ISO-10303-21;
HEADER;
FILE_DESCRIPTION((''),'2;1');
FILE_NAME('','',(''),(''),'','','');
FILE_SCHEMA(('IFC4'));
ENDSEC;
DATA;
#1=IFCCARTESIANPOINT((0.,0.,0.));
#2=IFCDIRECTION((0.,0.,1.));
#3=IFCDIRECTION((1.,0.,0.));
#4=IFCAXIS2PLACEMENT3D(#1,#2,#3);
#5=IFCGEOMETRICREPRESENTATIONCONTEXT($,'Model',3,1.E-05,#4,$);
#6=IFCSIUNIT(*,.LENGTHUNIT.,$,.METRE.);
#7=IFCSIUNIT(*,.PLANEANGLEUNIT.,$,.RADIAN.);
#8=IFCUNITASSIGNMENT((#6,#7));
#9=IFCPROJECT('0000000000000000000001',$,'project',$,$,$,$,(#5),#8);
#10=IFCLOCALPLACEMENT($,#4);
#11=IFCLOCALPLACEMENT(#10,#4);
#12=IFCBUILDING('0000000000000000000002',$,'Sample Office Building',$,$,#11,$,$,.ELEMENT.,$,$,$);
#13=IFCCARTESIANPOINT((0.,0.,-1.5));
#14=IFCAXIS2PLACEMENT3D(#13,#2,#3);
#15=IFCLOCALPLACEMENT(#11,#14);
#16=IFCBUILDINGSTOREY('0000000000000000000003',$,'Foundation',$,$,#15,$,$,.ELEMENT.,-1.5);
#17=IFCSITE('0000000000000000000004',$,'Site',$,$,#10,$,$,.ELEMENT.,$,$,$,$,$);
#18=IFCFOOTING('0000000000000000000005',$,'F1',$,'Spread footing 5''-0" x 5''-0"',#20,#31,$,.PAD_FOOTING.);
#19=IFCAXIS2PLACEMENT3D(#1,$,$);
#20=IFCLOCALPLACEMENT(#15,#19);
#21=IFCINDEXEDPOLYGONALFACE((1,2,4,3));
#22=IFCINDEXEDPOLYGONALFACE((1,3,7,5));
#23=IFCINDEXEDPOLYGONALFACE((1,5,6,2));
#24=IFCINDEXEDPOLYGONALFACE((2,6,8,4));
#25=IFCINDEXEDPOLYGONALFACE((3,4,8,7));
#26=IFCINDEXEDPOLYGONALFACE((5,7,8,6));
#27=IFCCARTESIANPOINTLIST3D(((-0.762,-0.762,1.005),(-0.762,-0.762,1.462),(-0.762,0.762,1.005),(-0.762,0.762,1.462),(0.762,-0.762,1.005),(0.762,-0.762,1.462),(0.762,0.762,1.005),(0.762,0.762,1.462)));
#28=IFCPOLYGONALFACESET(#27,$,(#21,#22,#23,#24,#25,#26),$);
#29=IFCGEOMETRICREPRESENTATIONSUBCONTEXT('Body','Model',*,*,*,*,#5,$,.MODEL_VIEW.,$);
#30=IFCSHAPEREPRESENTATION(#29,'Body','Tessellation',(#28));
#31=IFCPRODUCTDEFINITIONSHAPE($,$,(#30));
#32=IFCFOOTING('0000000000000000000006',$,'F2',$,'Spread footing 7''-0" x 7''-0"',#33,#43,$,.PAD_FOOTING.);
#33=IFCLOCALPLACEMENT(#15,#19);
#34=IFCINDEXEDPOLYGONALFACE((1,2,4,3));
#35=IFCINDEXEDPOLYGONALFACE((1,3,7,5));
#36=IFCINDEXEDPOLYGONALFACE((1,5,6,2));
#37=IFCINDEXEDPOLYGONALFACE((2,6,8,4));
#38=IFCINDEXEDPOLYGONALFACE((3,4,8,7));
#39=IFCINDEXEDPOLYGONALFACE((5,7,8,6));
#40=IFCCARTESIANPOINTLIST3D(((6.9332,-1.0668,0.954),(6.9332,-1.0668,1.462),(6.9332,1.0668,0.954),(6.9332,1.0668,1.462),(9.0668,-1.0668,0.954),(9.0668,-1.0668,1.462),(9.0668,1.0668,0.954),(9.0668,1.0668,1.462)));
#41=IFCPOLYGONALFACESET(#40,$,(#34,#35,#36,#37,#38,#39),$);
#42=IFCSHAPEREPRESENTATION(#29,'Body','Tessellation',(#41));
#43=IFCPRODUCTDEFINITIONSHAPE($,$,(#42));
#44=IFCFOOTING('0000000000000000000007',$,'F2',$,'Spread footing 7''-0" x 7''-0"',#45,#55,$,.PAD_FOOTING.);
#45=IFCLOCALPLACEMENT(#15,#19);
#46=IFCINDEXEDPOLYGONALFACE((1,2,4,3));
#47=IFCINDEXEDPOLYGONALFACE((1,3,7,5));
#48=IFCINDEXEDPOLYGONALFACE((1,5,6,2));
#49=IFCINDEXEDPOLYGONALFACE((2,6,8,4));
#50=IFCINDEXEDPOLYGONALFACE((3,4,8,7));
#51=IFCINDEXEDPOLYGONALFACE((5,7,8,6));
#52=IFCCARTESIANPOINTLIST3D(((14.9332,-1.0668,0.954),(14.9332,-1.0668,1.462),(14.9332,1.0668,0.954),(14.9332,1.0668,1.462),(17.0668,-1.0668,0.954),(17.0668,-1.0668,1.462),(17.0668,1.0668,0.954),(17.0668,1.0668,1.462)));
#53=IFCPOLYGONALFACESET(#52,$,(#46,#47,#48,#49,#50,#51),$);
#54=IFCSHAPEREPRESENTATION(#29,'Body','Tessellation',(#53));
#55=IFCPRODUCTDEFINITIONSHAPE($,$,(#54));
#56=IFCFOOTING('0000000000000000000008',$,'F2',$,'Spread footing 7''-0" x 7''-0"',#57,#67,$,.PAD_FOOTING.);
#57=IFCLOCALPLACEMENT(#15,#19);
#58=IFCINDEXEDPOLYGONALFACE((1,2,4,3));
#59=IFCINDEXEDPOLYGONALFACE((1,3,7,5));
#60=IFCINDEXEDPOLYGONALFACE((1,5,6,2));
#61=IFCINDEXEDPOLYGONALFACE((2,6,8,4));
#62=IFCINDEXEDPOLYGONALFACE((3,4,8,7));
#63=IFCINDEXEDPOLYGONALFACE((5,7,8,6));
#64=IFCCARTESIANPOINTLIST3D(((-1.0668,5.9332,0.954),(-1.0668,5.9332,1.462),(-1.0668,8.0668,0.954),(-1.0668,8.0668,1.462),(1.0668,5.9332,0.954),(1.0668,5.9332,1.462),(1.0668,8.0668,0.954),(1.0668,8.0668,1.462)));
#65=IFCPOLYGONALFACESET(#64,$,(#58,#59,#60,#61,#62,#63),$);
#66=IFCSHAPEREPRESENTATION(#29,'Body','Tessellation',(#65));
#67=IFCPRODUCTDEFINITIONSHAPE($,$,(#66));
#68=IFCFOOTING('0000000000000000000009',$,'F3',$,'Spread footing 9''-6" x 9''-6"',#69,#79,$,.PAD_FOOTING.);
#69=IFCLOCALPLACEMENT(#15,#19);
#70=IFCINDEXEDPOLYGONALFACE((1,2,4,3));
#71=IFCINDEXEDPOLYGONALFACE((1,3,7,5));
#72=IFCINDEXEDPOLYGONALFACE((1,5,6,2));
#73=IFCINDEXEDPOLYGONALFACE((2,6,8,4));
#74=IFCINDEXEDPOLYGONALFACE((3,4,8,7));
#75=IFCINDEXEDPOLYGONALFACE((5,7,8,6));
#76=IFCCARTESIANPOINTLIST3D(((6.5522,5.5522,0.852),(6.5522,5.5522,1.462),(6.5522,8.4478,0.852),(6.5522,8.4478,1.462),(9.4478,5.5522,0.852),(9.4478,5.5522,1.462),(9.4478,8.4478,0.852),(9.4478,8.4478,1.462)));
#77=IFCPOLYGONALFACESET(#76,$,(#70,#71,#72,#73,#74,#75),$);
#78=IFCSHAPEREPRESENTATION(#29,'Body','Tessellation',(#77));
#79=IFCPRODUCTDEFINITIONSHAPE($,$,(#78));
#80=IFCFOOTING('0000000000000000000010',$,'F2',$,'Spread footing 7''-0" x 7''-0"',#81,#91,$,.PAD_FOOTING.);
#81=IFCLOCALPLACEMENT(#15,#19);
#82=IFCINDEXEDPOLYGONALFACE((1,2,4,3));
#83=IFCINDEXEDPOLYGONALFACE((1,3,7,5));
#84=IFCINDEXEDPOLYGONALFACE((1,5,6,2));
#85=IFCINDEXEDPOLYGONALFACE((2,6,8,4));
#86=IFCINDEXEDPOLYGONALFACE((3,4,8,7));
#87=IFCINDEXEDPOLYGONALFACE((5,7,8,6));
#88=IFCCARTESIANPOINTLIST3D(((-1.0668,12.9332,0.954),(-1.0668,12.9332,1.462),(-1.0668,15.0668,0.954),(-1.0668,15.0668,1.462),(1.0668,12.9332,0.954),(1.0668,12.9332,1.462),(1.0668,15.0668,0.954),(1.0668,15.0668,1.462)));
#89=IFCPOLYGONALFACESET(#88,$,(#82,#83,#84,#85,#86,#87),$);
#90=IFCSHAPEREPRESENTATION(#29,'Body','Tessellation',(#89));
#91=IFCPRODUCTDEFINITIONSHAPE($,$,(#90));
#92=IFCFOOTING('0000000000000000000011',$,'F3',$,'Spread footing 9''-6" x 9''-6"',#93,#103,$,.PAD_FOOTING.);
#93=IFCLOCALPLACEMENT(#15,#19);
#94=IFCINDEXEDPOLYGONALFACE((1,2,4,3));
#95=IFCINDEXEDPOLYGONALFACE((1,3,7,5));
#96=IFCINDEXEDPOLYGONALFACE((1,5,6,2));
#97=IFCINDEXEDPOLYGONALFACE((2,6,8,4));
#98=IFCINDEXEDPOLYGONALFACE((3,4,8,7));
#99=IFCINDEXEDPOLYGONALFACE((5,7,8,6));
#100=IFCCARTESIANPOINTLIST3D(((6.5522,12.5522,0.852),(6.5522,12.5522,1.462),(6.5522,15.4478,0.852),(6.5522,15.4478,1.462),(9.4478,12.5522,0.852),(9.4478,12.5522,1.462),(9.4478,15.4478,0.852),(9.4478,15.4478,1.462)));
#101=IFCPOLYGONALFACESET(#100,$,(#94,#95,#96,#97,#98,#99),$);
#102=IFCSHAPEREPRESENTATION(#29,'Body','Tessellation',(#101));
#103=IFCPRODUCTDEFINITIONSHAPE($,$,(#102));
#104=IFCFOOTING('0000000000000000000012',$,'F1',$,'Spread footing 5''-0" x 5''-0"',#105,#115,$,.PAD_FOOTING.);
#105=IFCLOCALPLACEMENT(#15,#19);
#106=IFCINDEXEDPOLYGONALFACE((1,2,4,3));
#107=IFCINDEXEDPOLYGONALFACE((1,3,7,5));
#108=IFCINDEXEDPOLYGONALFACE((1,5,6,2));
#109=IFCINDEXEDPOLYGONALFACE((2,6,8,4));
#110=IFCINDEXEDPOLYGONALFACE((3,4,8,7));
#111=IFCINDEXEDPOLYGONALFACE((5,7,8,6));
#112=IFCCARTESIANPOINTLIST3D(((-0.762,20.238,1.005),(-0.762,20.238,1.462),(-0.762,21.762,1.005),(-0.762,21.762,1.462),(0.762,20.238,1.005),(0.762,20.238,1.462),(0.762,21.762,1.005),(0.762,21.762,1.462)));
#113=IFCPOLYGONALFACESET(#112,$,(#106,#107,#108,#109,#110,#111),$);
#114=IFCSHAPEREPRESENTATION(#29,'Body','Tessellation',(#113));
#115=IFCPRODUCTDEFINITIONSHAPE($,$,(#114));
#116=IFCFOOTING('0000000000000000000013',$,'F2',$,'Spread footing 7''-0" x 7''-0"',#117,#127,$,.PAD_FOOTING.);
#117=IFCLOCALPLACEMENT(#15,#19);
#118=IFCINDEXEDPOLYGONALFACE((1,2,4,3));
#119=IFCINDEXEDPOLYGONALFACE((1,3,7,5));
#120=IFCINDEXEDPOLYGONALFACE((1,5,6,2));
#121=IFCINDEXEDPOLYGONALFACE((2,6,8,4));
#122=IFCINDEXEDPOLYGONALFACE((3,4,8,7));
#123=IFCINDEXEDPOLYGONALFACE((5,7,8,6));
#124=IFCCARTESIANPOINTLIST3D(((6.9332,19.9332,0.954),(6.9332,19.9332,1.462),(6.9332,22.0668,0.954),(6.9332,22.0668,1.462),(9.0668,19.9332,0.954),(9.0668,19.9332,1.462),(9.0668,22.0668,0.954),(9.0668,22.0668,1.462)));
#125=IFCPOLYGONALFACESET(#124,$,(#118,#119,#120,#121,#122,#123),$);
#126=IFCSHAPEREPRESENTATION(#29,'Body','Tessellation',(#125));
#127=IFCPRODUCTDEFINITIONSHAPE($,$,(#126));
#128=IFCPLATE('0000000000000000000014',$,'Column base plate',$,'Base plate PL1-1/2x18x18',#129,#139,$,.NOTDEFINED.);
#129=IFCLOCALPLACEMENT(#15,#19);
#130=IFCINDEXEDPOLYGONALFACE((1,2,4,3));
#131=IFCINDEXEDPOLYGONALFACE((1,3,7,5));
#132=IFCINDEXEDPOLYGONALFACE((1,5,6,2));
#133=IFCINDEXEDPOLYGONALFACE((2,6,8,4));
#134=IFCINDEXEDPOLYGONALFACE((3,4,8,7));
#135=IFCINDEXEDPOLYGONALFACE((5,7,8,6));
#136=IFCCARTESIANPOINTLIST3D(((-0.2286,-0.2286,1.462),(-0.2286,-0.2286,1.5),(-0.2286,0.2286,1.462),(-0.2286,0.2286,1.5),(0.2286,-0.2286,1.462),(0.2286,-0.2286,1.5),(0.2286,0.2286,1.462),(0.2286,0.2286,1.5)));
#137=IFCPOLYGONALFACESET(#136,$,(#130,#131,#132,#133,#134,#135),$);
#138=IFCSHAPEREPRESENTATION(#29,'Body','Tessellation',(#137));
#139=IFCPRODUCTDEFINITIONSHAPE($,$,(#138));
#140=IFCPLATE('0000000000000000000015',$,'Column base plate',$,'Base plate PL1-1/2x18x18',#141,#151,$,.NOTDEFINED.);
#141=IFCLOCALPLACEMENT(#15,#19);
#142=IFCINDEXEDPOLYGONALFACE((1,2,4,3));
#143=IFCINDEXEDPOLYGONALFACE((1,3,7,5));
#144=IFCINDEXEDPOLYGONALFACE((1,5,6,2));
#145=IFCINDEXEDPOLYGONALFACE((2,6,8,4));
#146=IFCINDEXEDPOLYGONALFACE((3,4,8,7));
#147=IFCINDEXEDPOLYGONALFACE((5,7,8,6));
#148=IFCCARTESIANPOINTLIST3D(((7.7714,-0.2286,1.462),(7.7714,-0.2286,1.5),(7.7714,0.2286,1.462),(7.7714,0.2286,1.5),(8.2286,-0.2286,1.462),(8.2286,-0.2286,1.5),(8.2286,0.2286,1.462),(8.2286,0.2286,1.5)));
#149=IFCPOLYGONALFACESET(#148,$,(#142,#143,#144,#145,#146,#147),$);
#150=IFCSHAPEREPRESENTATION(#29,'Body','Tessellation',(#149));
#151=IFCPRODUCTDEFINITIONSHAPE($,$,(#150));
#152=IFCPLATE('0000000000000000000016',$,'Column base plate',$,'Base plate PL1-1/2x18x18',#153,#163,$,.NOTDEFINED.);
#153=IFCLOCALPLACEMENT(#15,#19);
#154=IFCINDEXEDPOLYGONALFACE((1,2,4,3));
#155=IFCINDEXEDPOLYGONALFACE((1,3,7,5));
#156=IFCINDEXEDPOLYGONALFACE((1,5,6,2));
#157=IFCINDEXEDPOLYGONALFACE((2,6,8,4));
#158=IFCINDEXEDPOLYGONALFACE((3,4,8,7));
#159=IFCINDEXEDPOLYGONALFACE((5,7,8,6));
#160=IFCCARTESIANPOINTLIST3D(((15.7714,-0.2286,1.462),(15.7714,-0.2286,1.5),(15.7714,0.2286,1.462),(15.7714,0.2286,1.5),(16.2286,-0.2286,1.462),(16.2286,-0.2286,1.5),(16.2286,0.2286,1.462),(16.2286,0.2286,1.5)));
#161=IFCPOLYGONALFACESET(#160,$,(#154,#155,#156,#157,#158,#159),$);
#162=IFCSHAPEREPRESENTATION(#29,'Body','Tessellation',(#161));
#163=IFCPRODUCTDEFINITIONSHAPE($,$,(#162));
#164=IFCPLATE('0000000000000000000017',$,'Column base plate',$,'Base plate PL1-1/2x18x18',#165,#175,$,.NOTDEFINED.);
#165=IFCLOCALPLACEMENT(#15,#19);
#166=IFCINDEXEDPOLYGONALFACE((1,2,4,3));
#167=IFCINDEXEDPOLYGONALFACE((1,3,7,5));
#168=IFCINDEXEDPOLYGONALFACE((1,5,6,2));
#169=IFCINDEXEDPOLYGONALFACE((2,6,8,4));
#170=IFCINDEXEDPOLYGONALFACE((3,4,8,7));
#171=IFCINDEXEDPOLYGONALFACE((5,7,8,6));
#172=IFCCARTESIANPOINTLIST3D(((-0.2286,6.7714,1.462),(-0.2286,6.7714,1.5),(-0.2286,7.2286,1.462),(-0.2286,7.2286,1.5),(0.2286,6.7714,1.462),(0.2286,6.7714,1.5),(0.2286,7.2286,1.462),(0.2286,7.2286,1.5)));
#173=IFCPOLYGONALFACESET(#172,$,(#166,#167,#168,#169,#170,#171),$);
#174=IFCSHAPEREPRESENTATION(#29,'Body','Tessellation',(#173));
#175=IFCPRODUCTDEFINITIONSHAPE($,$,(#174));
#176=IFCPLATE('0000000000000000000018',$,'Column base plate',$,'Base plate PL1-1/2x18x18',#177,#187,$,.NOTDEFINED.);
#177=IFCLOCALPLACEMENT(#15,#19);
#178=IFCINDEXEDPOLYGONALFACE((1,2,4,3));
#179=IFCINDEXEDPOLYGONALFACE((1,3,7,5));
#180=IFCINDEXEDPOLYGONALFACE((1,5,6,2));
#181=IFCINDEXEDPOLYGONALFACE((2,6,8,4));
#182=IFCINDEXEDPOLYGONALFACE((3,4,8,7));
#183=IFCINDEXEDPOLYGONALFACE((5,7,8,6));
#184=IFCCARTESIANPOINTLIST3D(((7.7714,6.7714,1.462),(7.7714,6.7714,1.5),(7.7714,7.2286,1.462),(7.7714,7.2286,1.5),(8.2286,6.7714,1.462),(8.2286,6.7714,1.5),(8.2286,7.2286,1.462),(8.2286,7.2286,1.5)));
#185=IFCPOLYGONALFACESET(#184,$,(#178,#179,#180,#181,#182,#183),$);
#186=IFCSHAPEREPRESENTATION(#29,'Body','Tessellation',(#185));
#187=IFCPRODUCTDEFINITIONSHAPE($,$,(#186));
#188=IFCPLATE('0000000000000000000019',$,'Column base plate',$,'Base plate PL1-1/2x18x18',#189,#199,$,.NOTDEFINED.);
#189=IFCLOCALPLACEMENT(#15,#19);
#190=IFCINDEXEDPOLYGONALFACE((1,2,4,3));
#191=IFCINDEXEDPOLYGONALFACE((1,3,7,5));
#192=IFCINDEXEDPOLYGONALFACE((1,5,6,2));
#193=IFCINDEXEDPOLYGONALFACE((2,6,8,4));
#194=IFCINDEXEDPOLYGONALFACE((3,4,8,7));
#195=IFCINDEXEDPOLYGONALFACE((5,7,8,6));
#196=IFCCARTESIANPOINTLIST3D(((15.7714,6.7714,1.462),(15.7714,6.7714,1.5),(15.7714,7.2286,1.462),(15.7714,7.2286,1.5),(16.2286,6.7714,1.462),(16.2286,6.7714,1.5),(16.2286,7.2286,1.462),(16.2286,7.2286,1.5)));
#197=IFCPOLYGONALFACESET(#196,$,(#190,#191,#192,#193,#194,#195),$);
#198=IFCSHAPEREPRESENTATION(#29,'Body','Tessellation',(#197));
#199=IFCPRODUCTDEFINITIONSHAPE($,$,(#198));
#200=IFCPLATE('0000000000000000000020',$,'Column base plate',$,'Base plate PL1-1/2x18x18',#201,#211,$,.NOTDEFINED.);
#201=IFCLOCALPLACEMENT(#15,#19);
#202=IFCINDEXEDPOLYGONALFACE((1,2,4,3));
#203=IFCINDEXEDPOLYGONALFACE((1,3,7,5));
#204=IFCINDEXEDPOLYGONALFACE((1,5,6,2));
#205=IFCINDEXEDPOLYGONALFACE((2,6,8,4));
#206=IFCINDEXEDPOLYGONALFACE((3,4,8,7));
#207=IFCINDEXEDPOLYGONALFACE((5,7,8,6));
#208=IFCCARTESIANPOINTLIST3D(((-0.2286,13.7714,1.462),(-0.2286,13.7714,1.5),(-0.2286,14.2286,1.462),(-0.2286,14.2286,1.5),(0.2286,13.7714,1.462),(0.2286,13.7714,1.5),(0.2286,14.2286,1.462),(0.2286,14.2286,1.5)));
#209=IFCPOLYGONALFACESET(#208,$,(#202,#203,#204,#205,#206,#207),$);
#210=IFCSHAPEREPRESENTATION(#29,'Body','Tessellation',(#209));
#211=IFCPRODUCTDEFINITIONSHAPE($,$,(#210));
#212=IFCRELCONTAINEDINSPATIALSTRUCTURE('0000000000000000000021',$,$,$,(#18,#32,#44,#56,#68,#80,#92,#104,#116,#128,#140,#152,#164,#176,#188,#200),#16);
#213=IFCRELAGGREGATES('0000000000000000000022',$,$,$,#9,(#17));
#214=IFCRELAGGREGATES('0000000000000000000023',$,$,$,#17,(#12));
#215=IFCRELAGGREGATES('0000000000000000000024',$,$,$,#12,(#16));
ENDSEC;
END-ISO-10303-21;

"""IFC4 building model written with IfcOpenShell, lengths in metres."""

from ifc_helpers import new_model, si_unit, frame, origin_with_axes, place, context, subcontext, project, spatial, rectangle, extrude, element, save


model = new_model("IFC4")

# Units and contexts
model_context = context("Model", 3, precision=1e-05, world=origin_with_axes())
body_context = subcontext(model_context, "Body", "Model", "MODEL_VIEW")
ifc_project = project(units=[si_unit("LENGTHUNIT", "METRE"), si_unit("PLANEANGLEUNIT", "RADIAN")], contexts=[model_context])

# Site, building, storey
site_placement = place(None, origin_with_axes())
site = spatial("IfcSite", under=ifc_project, at=site_placement, Name="Site", CompositionType="ELEMENT")
building_placement = place(site_placement, origin_with_axes())
building = spatial("IfcBuilding", under=site, at=building_placement, Name="Sample Office Building", CompositionType="ELEMENT")
storey_placement = place(building_placement, frame((0.0, 0.0, -1.5), z_axis=(0.0, 0.0, 1.0), x_axis=(1.0, 0.0, 0.0)))
storey = spatial("IfcBuildingStorey", under=building, at=storey_placement, Name="Foundation", CompositionType="ELEMENT", Elevation=-1.5)

# Footings
footing_1_placement = place(None, frame((0.0, 0.0, -0.495), z_axis=(0.0, 0.0, 1.0), x_axis=(1.0, 0.0, 0.0)))
element("IfcFooting", 1, at=footing_1_placement, inside=storey, Name="F1", ObjectType="Spread footing 5'-0\" x 5'-0\"", PredefinedType="PAD_FOOTING", context=body_context, shape_type="SweptSolid", body=[
    extrude(rectangle(XDim=1.524, YDim=1.524), None, (0.0, 0.0, 1.0), 0.457),
])
for number, where, z_axis, x_axis, name in (
    (2, (8.0, 0.0, -0.546), (0.0, 0.0, 1.0), (1.0, 0.0, 0.0), "F2"),
    (3, (16.0, 0.0, -0.546), (0.0, 0.0, 1.0), (1.0, 0.0, 0.0), "F2"),
):
    element("IfcFooting", number, at=place(None, frame(where, z_axis=z_axis, x_axis=x_axis)), inside=storey, Name=name, ObjectType="Spread footing 7'-0\" x 7'-0\"", PredefinedType="PAD_FOOTING", context=body_context, shape_type="SweptSolid", body=[
        extrude(rectangle(XDim=2.1336, YDim=2.1336), None, (0.0, 0.0, 1.0), 0.508),
    ])
footing_2_placement = place(None, frame((0.0, 7.0, -0.546), z_axis=(0.0, 0.0, 1.0), x_axis=(1.0, 0.0, 0.0)))
element("IfcFooting", 4, at=footing_2_placement, inside=storey, Name="F2", ObjectType="Spread footing 7'-0\" x 7'-0\"", PredefinedType="PAD_FOOTING", context=body_context, shape_type="SweptSolid", body=[
    extrude(rectangle(XDim=2.1336, YDim=2.1336), None, (0.0, 0.0, 1.0), 0.508),
])
footing_3_placement = place(None, frame((8.0, 7.0, -0.648), z_axis=(0.0, 0.0, 1.0), x_axis=(1.0, 0.0, 0.0)))
element("IfcFooting", 5, at=footing_3_placement, inside=storey, Name="F3", ObjectType="Spread footing 9'-6\" x 9'-6\"", PredefinedType="PAD_FOOTING", context=body_context, shape_type="SweptSolid", body=[
    extrude(rectangle(XDim=2.8956, YDim=2.8956), None, (0.0, 0.0, 1.0), 0.61),
])
footing_4_placement = place(None, frame((0.0, 14.0, -0.546), z_axis=(0.0, 0.0, 1.0), x_axis=(1.0, 0.0, 0.0)))
element("IfcFooting", 6, at=footing_4_placement, inside=storey, Name="F2", ObjectType="Spread footing 7'-0\" x 7'-0\"", PredefinedType="PAD_FOOTING", context=body_context, shape_type="SweptSolid", body=[
    extrude(rectangle(XDim=2.1336, YDim=2.1336), None, (0.0, 0.0, 1.0), 0.508),
])
footing_5_placement = place(None, frame((8.0, 14.0, -0.648), z_axis=(0.0, 0.0, 1.0), x_axis=(1.0, 0.0, 0.0)))
element("IfcFooting", 7, at=footing_5_placement, inside=storey, Name="F3", ObjectType="Spread footing 9'-6\" x 9'-6\"", PredefinedType="PAD_FOOTING", context=body_context, shape_type="SweptSolid", body=[
    extrude(rectangle(XDim=2.8956, YDim=2.8956), None, (0.0, 0.0, 1.0), 0.61),
])
footing_6_placement = place(None, frame((0.0, 21.0, -0.495), z_axis=(0.0, 0.0, 1.0), x_axis=(1.0, 0.0, 0.0)))
element("IfcFooting", 8, at=footing_6_placement, inside=storey, Name="F1", ObjectType="Spread footing 5'-0\" x 5'-0\"", PredefinedType="PAD_FOOTING", context=body_context, shape_type="SweptSolid", body=[
    extrude(rectangle(XDim=1.524, YDim=1.524), None, (0.0, 0.0, 1.0), 0.457),
])
footing_7_placement = place(None, frame((8.0, 21.0, -0.546), z_axis=(0.0, 0.0, 1.0), x_axis=(1.0, 0.0, 0.0)))
element("IfcFooting", 9, at=footing_7_placement, inside=storey, Name="F2", ObjectType="Spread footing 7'-0\" x 7'-0\"", PredefinedType="PAD_FOOTING", context=body_context, shape_type="SweptSolid", body=[
    extrude(rectangle(XDim=2.1336, YDim=2.1336), None, (0.0, 0.0, 1.0), 0.508),
])

# Plates
plate_1_placement = place(None, frame((0.0, 0.0, -0.038), z_axis=(0.0, 0.0, 1.0), x_axis=(1.0, 0.0, 0.0)))
element("IfcPlate", 10, at=plate_1_placement, inside=storey, Name="Column base plate", ObjectType="Base plate PL1-1/2x18x18", PredefinedType="NOTDEFINED", context=body_context, shape_type="SweptSolid", body=[
    extrude(rectangle(XDim=0.4572, YDim=0.4572), None, (0.0, 0.0, 1.0), 0.038),
])
for number, where, z_axis, x_axis, name in (
    (11, (8.0, 0.0, -0.038), (0.0, 0.0, 1.0), (1.0, 0.0, 0.0), "Column base plate"),
    (12, (16.0, 0.0, -0.038), (0.0, 0.0, 1.0), (1.0, 0.0, 0.0), "Column base plate"),
):
    element("IfcPlate", number, at=place(None, frame(where, z_axis=z_axis, x_axis=x_axis)), inside=storey, Name=name, ObjectType="Base plate PL1-1/2x18x18", PredefinedType="NOTDEFINED", context=body_context, shape_type="SweptSolid", body=[
        extrude(rectangle(XDim=0.4572, YDim=0.4572), None, (0.0, 0.0, 1.0), 0.038),
    ])
plate_2_placement = place(None, frame((0.0, 7.0, -0.038), z_axis=(0.0, 0.0, 1.0), x_axis=(1.0, 0.0, 0.0)))
element("IfcPlate", 13, at=plate_2_placement, inside=storey, Name="Column base plate", ObjectType="Base plate PL1-1/2x18x18", PredefinedType="NOTDEFINED", context=body_context, shape_type="SweptSolid", body=[
    extrude(rectangle(XDim=0.4572, YDim=0.4572), None, (0.0, 0.0, 1.0), 0.038),
])
for number, where, z_axis, x_axis, name in (
    (14, (8.0, 7.0, -0.038), (0.0, 0.0, 1.0), (1.0, 0.0, 0.0), "Column base plate"),
    (15, (16.0, 7.0, -0.038), (0.0, 0.0, 1.0), (1.0, 0.0, 0.0), "Column base plate"),
):
    element("IfcPlate", number, at=place(None, frame(where, z_axis=z_axis, x_axis=x_axis)), inside=storey, Name=name, ObjectType="Base plate PL1-1/2x18x18", PredefinedType="NOTDEFINED", context=body_context, shape_type="SweptSolid", body=[
        extrude(rectangle(XDim=0.4572, YDim=0.4572), None, (0.0, 0.0, 1.0), 0.038),
    ])
plate_3_placement = place(None, frame((0.0, 14.0, -0.038), z_axis=(0.0, 0.0, 1.0), x_axis=(1.0, 0.0, 0.0)))
element("IfcPlate", 16, at=plate_3_placement, inside=storey, Name="Column base plate", ObjectType="Base plate PL1-1/2x18x18", PredefinedType="NOTDEFINED", context=body_context, shape_type="SweptSolid", body=[
    extrude(rectangle(XDim=0.4572, YDim=0.4572), None, (0.0, 0.0, 1.0), 0.038),
])

save(model, "model.ifc")
